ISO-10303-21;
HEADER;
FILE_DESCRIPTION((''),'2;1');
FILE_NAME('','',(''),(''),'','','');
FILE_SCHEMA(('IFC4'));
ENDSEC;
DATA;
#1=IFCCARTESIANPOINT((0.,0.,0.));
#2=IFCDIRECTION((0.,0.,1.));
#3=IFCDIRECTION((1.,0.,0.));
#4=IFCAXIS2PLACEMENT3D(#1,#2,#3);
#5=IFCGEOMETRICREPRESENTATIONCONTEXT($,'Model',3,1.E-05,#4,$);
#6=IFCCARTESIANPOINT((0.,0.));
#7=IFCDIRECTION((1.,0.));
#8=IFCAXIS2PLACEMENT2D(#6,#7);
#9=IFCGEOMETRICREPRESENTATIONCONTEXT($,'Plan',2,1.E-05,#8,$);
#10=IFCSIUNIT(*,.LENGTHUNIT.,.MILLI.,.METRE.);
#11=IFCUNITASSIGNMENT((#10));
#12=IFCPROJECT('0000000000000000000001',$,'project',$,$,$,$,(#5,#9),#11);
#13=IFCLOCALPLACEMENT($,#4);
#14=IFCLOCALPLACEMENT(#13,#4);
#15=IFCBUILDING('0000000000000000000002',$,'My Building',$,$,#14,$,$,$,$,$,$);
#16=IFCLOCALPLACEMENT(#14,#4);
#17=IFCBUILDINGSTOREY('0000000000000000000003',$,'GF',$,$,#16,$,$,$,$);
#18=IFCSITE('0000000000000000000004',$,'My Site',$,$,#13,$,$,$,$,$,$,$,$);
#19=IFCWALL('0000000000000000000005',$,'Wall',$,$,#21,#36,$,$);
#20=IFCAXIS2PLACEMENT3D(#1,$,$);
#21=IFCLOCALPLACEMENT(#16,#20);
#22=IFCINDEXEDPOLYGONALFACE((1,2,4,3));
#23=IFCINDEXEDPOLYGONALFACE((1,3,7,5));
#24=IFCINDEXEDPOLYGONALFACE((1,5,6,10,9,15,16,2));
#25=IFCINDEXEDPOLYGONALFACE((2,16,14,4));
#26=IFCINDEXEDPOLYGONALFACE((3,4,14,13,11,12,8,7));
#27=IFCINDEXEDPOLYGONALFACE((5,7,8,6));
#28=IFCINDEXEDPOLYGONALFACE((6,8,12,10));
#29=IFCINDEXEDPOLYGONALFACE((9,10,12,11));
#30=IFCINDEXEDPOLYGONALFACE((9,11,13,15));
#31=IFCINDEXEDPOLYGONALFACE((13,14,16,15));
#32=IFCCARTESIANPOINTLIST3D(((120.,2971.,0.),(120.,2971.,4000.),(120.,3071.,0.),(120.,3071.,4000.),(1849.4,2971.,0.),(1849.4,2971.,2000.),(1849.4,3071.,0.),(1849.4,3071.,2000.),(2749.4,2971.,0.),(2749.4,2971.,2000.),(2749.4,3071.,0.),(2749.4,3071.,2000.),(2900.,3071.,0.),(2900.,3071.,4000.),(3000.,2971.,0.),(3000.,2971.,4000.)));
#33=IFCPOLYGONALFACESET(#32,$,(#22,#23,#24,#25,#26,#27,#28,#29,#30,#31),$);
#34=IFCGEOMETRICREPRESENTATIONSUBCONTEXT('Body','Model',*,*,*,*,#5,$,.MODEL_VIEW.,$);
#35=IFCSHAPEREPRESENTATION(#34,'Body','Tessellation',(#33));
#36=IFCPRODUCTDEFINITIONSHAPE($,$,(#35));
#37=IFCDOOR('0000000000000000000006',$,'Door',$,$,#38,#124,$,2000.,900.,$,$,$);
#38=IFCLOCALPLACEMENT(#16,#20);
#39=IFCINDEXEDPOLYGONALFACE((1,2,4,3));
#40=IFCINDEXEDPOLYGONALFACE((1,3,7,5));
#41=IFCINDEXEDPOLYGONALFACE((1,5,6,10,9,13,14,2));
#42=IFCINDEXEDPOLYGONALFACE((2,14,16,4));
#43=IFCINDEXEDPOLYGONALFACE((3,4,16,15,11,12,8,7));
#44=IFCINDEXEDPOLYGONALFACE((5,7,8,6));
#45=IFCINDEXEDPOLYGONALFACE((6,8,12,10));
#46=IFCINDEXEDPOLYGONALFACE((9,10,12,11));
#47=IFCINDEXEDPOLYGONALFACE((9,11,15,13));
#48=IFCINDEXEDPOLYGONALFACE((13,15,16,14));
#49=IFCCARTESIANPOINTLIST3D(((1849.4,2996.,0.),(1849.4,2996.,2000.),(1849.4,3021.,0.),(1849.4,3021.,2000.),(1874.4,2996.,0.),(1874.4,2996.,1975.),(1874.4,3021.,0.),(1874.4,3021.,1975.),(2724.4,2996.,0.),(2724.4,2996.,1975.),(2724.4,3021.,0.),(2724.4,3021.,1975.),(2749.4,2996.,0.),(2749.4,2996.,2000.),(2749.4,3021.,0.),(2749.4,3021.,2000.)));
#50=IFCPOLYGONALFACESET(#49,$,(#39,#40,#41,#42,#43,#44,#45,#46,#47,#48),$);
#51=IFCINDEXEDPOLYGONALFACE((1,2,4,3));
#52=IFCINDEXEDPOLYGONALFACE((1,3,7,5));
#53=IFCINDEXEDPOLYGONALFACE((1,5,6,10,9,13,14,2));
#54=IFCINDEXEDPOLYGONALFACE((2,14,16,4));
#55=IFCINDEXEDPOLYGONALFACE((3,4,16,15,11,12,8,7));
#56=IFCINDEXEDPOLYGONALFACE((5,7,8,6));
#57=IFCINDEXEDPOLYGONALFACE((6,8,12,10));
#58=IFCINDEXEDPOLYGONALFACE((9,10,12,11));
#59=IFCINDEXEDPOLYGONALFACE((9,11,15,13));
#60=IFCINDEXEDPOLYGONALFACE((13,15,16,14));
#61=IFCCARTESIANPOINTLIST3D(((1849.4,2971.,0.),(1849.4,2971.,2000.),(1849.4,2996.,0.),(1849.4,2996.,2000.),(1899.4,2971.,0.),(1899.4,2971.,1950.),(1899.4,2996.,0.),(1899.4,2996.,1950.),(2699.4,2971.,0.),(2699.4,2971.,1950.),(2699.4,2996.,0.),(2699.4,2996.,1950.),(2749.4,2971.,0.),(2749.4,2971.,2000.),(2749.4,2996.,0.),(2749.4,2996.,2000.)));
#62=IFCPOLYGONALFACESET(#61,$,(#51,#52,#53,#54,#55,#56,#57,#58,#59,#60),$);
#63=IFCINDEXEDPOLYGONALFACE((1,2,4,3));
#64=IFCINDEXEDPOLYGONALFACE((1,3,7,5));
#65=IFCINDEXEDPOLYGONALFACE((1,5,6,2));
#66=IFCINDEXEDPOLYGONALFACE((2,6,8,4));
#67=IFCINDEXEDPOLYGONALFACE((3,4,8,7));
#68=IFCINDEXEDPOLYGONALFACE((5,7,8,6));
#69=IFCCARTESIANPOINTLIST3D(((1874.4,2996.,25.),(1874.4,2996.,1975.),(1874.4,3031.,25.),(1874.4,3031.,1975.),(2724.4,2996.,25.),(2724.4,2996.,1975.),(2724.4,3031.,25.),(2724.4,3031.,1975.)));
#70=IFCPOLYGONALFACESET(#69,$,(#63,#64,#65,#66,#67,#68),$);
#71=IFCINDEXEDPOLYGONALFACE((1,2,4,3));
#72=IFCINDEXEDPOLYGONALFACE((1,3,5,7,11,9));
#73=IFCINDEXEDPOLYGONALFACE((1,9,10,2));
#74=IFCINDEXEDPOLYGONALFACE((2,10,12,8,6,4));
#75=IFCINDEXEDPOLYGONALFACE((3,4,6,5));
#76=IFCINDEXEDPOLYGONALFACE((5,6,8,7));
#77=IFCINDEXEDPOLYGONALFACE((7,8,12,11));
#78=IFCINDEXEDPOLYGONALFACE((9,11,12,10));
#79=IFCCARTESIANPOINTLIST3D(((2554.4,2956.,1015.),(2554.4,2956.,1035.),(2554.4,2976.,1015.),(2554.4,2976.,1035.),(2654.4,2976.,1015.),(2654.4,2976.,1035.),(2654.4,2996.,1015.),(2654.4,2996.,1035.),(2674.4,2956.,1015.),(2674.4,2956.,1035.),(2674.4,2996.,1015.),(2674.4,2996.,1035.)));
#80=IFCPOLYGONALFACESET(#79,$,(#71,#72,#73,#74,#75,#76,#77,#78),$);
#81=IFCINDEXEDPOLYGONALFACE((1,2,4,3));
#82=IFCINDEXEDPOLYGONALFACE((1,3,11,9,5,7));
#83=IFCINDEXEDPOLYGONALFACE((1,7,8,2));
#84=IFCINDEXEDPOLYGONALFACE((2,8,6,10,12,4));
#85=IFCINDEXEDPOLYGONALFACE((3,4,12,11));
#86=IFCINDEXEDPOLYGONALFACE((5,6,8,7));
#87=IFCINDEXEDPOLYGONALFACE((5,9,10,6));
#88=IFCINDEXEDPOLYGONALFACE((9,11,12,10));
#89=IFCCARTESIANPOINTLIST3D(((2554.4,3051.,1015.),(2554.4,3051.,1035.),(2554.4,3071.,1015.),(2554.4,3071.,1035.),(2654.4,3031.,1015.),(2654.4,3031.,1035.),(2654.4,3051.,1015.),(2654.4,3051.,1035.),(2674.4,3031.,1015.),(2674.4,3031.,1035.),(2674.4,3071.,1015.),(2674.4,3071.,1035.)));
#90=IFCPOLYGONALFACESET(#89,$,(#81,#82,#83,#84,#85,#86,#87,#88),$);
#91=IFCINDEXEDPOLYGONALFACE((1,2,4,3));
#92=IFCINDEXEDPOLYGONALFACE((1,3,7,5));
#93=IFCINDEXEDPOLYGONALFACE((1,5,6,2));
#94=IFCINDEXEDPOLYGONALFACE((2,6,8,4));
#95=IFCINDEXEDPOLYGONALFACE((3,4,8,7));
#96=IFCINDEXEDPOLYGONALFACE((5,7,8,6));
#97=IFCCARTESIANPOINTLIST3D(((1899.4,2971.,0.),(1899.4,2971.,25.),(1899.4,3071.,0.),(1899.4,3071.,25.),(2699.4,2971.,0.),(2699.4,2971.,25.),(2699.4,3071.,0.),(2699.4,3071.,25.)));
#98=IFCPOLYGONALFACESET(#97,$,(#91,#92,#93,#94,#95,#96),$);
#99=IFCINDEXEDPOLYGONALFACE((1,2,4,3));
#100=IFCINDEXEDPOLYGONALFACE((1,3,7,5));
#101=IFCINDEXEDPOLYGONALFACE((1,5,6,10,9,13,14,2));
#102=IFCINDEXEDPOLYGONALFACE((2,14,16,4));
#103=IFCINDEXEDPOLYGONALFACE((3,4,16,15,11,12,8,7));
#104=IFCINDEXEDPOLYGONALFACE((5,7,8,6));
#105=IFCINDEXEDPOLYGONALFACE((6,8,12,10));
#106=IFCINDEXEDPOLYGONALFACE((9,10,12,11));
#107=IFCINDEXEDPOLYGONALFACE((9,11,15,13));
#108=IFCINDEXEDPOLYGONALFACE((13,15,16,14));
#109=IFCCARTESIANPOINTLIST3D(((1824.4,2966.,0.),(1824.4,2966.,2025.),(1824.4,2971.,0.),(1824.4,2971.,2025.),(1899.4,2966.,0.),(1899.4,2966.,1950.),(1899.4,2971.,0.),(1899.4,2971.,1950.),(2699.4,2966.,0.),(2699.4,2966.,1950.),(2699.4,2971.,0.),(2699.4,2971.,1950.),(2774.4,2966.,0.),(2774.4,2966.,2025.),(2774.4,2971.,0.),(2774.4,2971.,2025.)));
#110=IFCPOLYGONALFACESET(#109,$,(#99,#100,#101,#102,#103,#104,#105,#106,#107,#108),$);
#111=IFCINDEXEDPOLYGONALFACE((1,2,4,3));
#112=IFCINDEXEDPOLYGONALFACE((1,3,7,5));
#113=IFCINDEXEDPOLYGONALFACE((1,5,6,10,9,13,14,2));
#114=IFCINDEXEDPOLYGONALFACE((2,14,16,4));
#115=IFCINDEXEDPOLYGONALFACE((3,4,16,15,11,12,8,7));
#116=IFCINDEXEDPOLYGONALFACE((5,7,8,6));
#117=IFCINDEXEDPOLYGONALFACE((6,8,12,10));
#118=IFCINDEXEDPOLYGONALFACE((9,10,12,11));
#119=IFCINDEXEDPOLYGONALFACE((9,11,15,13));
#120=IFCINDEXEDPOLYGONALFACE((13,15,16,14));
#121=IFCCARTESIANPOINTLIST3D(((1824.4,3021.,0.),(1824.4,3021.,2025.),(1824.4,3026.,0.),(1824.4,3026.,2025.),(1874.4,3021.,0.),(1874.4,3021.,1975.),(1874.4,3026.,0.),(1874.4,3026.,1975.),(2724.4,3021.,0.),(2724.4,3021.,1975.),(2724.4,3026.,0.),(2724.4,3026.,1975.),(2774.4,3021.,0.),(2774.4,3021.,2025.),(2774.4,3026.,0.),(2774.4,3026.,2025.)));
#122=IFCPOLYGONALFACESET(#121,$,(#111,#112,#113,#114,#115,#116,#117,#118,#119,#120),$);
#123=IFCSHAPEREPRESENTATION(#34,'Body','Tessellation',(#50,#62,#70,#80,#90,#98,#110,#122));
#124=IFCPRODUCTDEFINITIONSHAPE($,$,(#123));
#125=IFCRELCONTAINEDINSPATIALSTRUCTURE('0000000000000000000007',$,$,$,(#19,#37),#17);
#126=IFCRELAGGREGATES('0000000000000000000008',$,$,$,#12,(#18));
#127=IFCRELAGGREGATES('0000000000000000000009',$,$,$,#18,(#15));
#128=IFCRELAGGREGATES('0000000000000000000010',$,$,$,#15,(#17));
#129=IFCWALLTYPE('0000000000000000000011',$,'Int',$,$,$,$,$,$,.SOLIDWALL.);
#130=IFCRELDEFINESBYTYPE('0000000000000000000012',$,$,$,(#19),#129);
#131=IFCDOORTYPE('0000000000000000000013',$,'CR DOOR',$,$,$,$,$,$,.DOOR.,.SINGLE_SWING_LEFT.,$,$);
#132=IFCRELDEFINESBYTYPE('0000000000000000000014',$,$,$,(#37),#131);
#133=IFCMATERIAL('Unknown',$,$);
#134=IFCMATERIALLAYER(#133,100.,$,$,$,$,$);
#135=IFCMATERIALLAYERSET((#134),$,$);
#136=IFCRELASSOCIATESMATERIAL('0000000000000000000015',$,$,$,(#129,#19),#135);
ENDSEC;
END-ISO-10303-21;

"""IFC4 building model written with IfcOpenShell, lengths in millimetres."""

from ifc_helpers import new_model, entity, si_unit, frame, origin_with_axes, origin_2d_with_axis, place, context, subcontext, project, spatial, line, indexed_curve, outline, extrude, shape, source, transform, mapped, material, layer, layer_set, layer_usage, type_object, type_shapes, element, fill, save


model = new_model("IFC4")

# Units and contexts
model_context = context("Model", 3, precision=1e-05, world=origin_with_axes())
plan_context = context("Plan", 2, precision=1e-05, world=origin_2d_with_axis())
body_context_1 = subcontext(model_context, "Body", "Model", "MODEL_VIEW")
body_context_2 = subcontext(plan_context, "Body", "Plan", "PLAN_VIEW")
ifc_project = project(units=[si_unit("LENGTHUNIT", "METRE", prefix="MILLI")], contexts=[model_context, plan_context])

# Site, building, storey
site_placement = place(None, origin_with_axes())
site = spatial("IfcSite", under=ifc_project, at=site_placement, Name="My Site")
building_placement = place(site_placement, origin_with_axes())
building = spatial("IfcBuilding", under=site, at=building_placement, Name="My Building")
storey_placement = place(building_placement, origin_with_axes())
storey = spatial("IfcBuildingStorey", under=building, at=storey_placement, Name="GF")

# Shared definitions
ifc_material = material(Name="Unknown")

# Shared definitions
ifc_layer_1 = layer(ifc_material, 100.0)
ifc_layer_set_1 = layer_set([ifc_layer_1])
wall_type_1 = type_object("IfcWallType", Name="Int", PredefinedType="SOLIDWALL", material=ifc_layer_set_1)

# Wall, opening, door
ifc_layer_usage_1 = layer_usage(ifc_layer_set_1, "AXIS2", "POSITIVE", 0.0)
wall_1_placement = place(storey_placement, frame((2900.0, 3071.0, 0.0), z_axis=(0.0, 0.0, 1.0), x_axis=(-1.0, 0.0, 0.0)))
wall_1 = element("IfcWall", 1, at=wall_1_placement, inside=storey, type_object=wall_type_1, material=ifc_layer_usage_1, Name="Wall", context=body_context_1, shape_type="SweptSolid", body=[
    extrude(outline(indexed_curve([(0.0, 0.0), (-100.0, 100.0), (2780.0, 100.0), (2780.0, 0.0)], segments=[line(1, 2, 3, 4, 1)])), origin_with_axes(), (0.0, 0.0, 1.0), 4000.0),
])
shared_shape_1 = source(origin_with_axes(), body_context_1, "Body", "SweptSolid", [
    extrude(outline(indexed_curve([(0.0, 0.0), (900.0, 0.0), (900.0, 2000.0), (0.0, 2000.0)], segments=[line(1, 2, 3, 4, 1)])), frame((0.0, -600.0, 0.0), z_axis=(0.0, -1.0, 0.0), x_axis=(1.0, 0.0, 0.0)), (0.0, 0.0, -1.0), 1200.0),
])
opening_1_placement = place(wall_1_placement, frame((1050.6, 100.0, 0.0), z_axis=(0.0, 0.0, 1.0), x_axis=(-1.0, 0.0, 0.0)))
opening_1 = element("IfcOpeningElement", 2, at=opening_1_placement, cuts=wall_1, PredefinedType="OPENING", context=body_context_1, shape_type="MappedRepresentation", body=[
    mapped(shared_shape_1, transform((0.0, 0.0, 0.0), x_axis=(1.0, 0.0, 0.0), y_axis=(0.0, 1.0, 0.0), z_axis=(0.0, 0.0, 1.0), scale=1.0)),
])
door_type_1 = type_object("IfcDoorType", Name="CR DOOR", OperationType="SINGLE_SWING_LEFT", PredefinedType="DOOR")
shared_shape_2 = source(origin_with_axes(), body_context_1, "Body", "SweptSolid", [
    extrude(outline(indexed_curve([(0.0, 0.0), (0.0, 2000.0), (900.0, 2000.0), (900.0, 0.0), (875.0, 0.0), (875.0, 1975.0), (25.0, 1975.0), (25.0, 0.0)], segments=[line(1, 2, 3, 4, 5, 6, 7, 8, 1)])), frame((0.0, 25.0, 0.0), z_axis=(0.0, -1.0, 0.0), x_axis=(1.0, 0.0, 0.0)), (0.0, 0.0, -1.0), 25.0),
    extrude(outline(indexed_curve([(0.0, 0.0), (0.0, 2000.0), (900.0, 2000.0), (900.0, 0.0), (850.0, 0.0), (850.0, 1950.0), (50.0, 1950.0), (50.0, 0.0)], segments=[line(1, 2, 3, 4, 5, 6, 7, 8, 1)])), frame((0.0, 0.0, 0.0), z_axis=(0.0, -1.0, 0.0), x_axis=(1.0, 0.0, 0.0)), (0.0, 0.0, -1.0), 25.0),
    extrude(outline(indexed_curve([(0.0, 0.0), (850.0, 0.0), (850.0, 35.0), (0.0, 35.0)], segments=[line(1, 2, 3, 4, 1)])), frame((25.0, 25.0, 25.0), z_axis=(0.0, 0.0, 1.0), x_axis=(1.0, 0.0, 0.0)), (0.0, 0.0, 1.0), 1950.0),
    extrude(outline(indexed_curve([(0.0, 0.0), (0.0, -40.0), (-120.0, -40.0), (-120.0, -20.0), (-20.0, -20.0), (-20.0, 0.0)], segments=[line(1, 2, 3, 4, 5, 6, 1)])), frame((825.0, 25.0, 1015.0), z_axis=(0.0, 0.0, 1.0), x_axis=(1.0, 0.0, 0.0)), (0.0, 0.0, 1.0), 20.0),
    extrude(outline(indexed_curve([(0.0, 0.0), (0.0, 40.0), (-120.0, 40.0), (-120.0, 20.0), (-20.0, 20.0), (-20.0, 0.0)], segments=[line(1, 2, 3, 4, 5, 6, 1)])), frame((825.0, 60.0, 1015.0), z_axis=(0.0, 0.0, 1.0), x_axis=(1.0, 0.0, 0.0)), (0.0, 0.0, 1.0), 20.0),
    extrude(outline(indexed_curve([(0.0, 0.0), (800.0, 0.0), (800.0, 100.0), (0.0, 100.0)], segments=[line(1, 2, 3, 4, 1)])), frame((50.0, 0.0, 0.0), z_axis=(0.0, 0.0, 1.0), x_axis=(1.0, 0.0, 0.0)), (0.0, 0.0, 1.0), 25.0),
    extrude(outline(indexed_curve([(0.0, 0.0), (0.0, 2025.0), (950.0, 2025.0), (950.0, 0.0), (875.0, 0.0), (875.0, 1950.0), (75.0, 1950.0), (75.0, 0.0)], segments=[line(1, 2, 3, 4, 5, 6, 7, 8, 1)])), frame((-25.0, -5.0, 0.0), z_axis=(0.0, -1.0, 0.0), x_axis=(1.0, 0.0, 0.0)), (0.0, 0.0, -1.0), 5.0),
    extrude(outline(indexed_curve([(0.0, 0.0), (0.0, 2025.0), (950.0, 2025.0), (950.0, 0.0), (900.0, 0.0), (900.0, 1975.0), (50.0, 1975.0), (50.0, 0.0)], segments=[line(1, 2, 3, 4, 5, 6, 7, 8, 1)])), frame((-25.0, 50.0, 0.0), z_axis=(0.0, -1.0, 0.0), x_axis=(1.0, 0.0, 0.0)), (0.0, 0.0, -1.0), 5.0),
])
shared_shape_3 = source(origin_with_axes(), body_context_2, "Body", "Curve2D", [
    entity("IfcIndexedPolyCurve", entity("IfcCartesianPointList2D", [[0.0, 0.0], [0.0, 50.0], [25.0, 50.0], [25.0, 25.0], [50.0, 25.0], [50.0, 0.0]]), [entity("IfcLineIndex", [1, 2, 3, 4, 5, 6, 1])]),
    entity("IfcIndexedPolyCurve", entity("IfcCartesianPointList2D", [[900.0, 0.0], [900.0, 50.0], [875.0, 50.0], [875.0, 25.0], [850.0, 25.0], [850.0, 0.0]]), [entity("IfcLineIndex", [1, 2, 3, 4, 5, 6, 1])]),
    entity("IfcTrimmedCurve", entity("IfcEllipse", entity("IfcAxis2Placement2D", entity("IfcCartesianPoint", [60.0, 50.0]), entity("IfcDirection", [1.0, 0.0])), 815.0, 850.0), [entity("IfcCartesianPoint", [875.0, 50.0])], [entity("IfcCartesianPoint", [60.0, 900.0])], True, "CARTESIAN"),
    entity("IfcIndexedPolyCurve", entity("IfcCartesianPointList2D", [[25.0, 50.0], [60.0, 50.0], [60.0, 900.0], [25.0, 900.0]]), [entity("IfcLineIndex", [1, 2, 3, 4, 1])]),
])
type_shapes(door_type_1, [shared_shape_2, shared_shape_3])
door_1_placement = place(opening_1_placement, frame((0.0, 0.0, 0.0), z_axis=(0.0, 0.0, 1.0), x_axis=(1.0, 0.0, 0.0)))
door_1 = element("IfcDoor", 3, at=door_1_placement, inside=storey, type_object=door_type_1, Name="Door", OverallHeight=2000.0, OverallWidth=900.0, shapes=[
    shape(body_context_1, "Body", "MappedRepresentation", [mapped(shared_shape_2, transform((0.0, 0.0, 0.0), x_axis=(1.0, 0.0, 0.0), y_axis=(0.0, 1.0, 0.0), z_axis=(0.0, 0.0, 1.0), scale=1.0))]),
    shape(body_context_2, "Body", "MappedRepresentation", [mapped(shared_shape_3, transform((0.0, 0.0, 0.0), x_axis=(1.0, 0.0, 0.0), y_axis=(0.0, 1.0, 0.0), z_axis=(0.0, 0.0, 1.0), scale=1.0))]),
])
fill(opening_1, door_1)

save(model, "model.ifc")
